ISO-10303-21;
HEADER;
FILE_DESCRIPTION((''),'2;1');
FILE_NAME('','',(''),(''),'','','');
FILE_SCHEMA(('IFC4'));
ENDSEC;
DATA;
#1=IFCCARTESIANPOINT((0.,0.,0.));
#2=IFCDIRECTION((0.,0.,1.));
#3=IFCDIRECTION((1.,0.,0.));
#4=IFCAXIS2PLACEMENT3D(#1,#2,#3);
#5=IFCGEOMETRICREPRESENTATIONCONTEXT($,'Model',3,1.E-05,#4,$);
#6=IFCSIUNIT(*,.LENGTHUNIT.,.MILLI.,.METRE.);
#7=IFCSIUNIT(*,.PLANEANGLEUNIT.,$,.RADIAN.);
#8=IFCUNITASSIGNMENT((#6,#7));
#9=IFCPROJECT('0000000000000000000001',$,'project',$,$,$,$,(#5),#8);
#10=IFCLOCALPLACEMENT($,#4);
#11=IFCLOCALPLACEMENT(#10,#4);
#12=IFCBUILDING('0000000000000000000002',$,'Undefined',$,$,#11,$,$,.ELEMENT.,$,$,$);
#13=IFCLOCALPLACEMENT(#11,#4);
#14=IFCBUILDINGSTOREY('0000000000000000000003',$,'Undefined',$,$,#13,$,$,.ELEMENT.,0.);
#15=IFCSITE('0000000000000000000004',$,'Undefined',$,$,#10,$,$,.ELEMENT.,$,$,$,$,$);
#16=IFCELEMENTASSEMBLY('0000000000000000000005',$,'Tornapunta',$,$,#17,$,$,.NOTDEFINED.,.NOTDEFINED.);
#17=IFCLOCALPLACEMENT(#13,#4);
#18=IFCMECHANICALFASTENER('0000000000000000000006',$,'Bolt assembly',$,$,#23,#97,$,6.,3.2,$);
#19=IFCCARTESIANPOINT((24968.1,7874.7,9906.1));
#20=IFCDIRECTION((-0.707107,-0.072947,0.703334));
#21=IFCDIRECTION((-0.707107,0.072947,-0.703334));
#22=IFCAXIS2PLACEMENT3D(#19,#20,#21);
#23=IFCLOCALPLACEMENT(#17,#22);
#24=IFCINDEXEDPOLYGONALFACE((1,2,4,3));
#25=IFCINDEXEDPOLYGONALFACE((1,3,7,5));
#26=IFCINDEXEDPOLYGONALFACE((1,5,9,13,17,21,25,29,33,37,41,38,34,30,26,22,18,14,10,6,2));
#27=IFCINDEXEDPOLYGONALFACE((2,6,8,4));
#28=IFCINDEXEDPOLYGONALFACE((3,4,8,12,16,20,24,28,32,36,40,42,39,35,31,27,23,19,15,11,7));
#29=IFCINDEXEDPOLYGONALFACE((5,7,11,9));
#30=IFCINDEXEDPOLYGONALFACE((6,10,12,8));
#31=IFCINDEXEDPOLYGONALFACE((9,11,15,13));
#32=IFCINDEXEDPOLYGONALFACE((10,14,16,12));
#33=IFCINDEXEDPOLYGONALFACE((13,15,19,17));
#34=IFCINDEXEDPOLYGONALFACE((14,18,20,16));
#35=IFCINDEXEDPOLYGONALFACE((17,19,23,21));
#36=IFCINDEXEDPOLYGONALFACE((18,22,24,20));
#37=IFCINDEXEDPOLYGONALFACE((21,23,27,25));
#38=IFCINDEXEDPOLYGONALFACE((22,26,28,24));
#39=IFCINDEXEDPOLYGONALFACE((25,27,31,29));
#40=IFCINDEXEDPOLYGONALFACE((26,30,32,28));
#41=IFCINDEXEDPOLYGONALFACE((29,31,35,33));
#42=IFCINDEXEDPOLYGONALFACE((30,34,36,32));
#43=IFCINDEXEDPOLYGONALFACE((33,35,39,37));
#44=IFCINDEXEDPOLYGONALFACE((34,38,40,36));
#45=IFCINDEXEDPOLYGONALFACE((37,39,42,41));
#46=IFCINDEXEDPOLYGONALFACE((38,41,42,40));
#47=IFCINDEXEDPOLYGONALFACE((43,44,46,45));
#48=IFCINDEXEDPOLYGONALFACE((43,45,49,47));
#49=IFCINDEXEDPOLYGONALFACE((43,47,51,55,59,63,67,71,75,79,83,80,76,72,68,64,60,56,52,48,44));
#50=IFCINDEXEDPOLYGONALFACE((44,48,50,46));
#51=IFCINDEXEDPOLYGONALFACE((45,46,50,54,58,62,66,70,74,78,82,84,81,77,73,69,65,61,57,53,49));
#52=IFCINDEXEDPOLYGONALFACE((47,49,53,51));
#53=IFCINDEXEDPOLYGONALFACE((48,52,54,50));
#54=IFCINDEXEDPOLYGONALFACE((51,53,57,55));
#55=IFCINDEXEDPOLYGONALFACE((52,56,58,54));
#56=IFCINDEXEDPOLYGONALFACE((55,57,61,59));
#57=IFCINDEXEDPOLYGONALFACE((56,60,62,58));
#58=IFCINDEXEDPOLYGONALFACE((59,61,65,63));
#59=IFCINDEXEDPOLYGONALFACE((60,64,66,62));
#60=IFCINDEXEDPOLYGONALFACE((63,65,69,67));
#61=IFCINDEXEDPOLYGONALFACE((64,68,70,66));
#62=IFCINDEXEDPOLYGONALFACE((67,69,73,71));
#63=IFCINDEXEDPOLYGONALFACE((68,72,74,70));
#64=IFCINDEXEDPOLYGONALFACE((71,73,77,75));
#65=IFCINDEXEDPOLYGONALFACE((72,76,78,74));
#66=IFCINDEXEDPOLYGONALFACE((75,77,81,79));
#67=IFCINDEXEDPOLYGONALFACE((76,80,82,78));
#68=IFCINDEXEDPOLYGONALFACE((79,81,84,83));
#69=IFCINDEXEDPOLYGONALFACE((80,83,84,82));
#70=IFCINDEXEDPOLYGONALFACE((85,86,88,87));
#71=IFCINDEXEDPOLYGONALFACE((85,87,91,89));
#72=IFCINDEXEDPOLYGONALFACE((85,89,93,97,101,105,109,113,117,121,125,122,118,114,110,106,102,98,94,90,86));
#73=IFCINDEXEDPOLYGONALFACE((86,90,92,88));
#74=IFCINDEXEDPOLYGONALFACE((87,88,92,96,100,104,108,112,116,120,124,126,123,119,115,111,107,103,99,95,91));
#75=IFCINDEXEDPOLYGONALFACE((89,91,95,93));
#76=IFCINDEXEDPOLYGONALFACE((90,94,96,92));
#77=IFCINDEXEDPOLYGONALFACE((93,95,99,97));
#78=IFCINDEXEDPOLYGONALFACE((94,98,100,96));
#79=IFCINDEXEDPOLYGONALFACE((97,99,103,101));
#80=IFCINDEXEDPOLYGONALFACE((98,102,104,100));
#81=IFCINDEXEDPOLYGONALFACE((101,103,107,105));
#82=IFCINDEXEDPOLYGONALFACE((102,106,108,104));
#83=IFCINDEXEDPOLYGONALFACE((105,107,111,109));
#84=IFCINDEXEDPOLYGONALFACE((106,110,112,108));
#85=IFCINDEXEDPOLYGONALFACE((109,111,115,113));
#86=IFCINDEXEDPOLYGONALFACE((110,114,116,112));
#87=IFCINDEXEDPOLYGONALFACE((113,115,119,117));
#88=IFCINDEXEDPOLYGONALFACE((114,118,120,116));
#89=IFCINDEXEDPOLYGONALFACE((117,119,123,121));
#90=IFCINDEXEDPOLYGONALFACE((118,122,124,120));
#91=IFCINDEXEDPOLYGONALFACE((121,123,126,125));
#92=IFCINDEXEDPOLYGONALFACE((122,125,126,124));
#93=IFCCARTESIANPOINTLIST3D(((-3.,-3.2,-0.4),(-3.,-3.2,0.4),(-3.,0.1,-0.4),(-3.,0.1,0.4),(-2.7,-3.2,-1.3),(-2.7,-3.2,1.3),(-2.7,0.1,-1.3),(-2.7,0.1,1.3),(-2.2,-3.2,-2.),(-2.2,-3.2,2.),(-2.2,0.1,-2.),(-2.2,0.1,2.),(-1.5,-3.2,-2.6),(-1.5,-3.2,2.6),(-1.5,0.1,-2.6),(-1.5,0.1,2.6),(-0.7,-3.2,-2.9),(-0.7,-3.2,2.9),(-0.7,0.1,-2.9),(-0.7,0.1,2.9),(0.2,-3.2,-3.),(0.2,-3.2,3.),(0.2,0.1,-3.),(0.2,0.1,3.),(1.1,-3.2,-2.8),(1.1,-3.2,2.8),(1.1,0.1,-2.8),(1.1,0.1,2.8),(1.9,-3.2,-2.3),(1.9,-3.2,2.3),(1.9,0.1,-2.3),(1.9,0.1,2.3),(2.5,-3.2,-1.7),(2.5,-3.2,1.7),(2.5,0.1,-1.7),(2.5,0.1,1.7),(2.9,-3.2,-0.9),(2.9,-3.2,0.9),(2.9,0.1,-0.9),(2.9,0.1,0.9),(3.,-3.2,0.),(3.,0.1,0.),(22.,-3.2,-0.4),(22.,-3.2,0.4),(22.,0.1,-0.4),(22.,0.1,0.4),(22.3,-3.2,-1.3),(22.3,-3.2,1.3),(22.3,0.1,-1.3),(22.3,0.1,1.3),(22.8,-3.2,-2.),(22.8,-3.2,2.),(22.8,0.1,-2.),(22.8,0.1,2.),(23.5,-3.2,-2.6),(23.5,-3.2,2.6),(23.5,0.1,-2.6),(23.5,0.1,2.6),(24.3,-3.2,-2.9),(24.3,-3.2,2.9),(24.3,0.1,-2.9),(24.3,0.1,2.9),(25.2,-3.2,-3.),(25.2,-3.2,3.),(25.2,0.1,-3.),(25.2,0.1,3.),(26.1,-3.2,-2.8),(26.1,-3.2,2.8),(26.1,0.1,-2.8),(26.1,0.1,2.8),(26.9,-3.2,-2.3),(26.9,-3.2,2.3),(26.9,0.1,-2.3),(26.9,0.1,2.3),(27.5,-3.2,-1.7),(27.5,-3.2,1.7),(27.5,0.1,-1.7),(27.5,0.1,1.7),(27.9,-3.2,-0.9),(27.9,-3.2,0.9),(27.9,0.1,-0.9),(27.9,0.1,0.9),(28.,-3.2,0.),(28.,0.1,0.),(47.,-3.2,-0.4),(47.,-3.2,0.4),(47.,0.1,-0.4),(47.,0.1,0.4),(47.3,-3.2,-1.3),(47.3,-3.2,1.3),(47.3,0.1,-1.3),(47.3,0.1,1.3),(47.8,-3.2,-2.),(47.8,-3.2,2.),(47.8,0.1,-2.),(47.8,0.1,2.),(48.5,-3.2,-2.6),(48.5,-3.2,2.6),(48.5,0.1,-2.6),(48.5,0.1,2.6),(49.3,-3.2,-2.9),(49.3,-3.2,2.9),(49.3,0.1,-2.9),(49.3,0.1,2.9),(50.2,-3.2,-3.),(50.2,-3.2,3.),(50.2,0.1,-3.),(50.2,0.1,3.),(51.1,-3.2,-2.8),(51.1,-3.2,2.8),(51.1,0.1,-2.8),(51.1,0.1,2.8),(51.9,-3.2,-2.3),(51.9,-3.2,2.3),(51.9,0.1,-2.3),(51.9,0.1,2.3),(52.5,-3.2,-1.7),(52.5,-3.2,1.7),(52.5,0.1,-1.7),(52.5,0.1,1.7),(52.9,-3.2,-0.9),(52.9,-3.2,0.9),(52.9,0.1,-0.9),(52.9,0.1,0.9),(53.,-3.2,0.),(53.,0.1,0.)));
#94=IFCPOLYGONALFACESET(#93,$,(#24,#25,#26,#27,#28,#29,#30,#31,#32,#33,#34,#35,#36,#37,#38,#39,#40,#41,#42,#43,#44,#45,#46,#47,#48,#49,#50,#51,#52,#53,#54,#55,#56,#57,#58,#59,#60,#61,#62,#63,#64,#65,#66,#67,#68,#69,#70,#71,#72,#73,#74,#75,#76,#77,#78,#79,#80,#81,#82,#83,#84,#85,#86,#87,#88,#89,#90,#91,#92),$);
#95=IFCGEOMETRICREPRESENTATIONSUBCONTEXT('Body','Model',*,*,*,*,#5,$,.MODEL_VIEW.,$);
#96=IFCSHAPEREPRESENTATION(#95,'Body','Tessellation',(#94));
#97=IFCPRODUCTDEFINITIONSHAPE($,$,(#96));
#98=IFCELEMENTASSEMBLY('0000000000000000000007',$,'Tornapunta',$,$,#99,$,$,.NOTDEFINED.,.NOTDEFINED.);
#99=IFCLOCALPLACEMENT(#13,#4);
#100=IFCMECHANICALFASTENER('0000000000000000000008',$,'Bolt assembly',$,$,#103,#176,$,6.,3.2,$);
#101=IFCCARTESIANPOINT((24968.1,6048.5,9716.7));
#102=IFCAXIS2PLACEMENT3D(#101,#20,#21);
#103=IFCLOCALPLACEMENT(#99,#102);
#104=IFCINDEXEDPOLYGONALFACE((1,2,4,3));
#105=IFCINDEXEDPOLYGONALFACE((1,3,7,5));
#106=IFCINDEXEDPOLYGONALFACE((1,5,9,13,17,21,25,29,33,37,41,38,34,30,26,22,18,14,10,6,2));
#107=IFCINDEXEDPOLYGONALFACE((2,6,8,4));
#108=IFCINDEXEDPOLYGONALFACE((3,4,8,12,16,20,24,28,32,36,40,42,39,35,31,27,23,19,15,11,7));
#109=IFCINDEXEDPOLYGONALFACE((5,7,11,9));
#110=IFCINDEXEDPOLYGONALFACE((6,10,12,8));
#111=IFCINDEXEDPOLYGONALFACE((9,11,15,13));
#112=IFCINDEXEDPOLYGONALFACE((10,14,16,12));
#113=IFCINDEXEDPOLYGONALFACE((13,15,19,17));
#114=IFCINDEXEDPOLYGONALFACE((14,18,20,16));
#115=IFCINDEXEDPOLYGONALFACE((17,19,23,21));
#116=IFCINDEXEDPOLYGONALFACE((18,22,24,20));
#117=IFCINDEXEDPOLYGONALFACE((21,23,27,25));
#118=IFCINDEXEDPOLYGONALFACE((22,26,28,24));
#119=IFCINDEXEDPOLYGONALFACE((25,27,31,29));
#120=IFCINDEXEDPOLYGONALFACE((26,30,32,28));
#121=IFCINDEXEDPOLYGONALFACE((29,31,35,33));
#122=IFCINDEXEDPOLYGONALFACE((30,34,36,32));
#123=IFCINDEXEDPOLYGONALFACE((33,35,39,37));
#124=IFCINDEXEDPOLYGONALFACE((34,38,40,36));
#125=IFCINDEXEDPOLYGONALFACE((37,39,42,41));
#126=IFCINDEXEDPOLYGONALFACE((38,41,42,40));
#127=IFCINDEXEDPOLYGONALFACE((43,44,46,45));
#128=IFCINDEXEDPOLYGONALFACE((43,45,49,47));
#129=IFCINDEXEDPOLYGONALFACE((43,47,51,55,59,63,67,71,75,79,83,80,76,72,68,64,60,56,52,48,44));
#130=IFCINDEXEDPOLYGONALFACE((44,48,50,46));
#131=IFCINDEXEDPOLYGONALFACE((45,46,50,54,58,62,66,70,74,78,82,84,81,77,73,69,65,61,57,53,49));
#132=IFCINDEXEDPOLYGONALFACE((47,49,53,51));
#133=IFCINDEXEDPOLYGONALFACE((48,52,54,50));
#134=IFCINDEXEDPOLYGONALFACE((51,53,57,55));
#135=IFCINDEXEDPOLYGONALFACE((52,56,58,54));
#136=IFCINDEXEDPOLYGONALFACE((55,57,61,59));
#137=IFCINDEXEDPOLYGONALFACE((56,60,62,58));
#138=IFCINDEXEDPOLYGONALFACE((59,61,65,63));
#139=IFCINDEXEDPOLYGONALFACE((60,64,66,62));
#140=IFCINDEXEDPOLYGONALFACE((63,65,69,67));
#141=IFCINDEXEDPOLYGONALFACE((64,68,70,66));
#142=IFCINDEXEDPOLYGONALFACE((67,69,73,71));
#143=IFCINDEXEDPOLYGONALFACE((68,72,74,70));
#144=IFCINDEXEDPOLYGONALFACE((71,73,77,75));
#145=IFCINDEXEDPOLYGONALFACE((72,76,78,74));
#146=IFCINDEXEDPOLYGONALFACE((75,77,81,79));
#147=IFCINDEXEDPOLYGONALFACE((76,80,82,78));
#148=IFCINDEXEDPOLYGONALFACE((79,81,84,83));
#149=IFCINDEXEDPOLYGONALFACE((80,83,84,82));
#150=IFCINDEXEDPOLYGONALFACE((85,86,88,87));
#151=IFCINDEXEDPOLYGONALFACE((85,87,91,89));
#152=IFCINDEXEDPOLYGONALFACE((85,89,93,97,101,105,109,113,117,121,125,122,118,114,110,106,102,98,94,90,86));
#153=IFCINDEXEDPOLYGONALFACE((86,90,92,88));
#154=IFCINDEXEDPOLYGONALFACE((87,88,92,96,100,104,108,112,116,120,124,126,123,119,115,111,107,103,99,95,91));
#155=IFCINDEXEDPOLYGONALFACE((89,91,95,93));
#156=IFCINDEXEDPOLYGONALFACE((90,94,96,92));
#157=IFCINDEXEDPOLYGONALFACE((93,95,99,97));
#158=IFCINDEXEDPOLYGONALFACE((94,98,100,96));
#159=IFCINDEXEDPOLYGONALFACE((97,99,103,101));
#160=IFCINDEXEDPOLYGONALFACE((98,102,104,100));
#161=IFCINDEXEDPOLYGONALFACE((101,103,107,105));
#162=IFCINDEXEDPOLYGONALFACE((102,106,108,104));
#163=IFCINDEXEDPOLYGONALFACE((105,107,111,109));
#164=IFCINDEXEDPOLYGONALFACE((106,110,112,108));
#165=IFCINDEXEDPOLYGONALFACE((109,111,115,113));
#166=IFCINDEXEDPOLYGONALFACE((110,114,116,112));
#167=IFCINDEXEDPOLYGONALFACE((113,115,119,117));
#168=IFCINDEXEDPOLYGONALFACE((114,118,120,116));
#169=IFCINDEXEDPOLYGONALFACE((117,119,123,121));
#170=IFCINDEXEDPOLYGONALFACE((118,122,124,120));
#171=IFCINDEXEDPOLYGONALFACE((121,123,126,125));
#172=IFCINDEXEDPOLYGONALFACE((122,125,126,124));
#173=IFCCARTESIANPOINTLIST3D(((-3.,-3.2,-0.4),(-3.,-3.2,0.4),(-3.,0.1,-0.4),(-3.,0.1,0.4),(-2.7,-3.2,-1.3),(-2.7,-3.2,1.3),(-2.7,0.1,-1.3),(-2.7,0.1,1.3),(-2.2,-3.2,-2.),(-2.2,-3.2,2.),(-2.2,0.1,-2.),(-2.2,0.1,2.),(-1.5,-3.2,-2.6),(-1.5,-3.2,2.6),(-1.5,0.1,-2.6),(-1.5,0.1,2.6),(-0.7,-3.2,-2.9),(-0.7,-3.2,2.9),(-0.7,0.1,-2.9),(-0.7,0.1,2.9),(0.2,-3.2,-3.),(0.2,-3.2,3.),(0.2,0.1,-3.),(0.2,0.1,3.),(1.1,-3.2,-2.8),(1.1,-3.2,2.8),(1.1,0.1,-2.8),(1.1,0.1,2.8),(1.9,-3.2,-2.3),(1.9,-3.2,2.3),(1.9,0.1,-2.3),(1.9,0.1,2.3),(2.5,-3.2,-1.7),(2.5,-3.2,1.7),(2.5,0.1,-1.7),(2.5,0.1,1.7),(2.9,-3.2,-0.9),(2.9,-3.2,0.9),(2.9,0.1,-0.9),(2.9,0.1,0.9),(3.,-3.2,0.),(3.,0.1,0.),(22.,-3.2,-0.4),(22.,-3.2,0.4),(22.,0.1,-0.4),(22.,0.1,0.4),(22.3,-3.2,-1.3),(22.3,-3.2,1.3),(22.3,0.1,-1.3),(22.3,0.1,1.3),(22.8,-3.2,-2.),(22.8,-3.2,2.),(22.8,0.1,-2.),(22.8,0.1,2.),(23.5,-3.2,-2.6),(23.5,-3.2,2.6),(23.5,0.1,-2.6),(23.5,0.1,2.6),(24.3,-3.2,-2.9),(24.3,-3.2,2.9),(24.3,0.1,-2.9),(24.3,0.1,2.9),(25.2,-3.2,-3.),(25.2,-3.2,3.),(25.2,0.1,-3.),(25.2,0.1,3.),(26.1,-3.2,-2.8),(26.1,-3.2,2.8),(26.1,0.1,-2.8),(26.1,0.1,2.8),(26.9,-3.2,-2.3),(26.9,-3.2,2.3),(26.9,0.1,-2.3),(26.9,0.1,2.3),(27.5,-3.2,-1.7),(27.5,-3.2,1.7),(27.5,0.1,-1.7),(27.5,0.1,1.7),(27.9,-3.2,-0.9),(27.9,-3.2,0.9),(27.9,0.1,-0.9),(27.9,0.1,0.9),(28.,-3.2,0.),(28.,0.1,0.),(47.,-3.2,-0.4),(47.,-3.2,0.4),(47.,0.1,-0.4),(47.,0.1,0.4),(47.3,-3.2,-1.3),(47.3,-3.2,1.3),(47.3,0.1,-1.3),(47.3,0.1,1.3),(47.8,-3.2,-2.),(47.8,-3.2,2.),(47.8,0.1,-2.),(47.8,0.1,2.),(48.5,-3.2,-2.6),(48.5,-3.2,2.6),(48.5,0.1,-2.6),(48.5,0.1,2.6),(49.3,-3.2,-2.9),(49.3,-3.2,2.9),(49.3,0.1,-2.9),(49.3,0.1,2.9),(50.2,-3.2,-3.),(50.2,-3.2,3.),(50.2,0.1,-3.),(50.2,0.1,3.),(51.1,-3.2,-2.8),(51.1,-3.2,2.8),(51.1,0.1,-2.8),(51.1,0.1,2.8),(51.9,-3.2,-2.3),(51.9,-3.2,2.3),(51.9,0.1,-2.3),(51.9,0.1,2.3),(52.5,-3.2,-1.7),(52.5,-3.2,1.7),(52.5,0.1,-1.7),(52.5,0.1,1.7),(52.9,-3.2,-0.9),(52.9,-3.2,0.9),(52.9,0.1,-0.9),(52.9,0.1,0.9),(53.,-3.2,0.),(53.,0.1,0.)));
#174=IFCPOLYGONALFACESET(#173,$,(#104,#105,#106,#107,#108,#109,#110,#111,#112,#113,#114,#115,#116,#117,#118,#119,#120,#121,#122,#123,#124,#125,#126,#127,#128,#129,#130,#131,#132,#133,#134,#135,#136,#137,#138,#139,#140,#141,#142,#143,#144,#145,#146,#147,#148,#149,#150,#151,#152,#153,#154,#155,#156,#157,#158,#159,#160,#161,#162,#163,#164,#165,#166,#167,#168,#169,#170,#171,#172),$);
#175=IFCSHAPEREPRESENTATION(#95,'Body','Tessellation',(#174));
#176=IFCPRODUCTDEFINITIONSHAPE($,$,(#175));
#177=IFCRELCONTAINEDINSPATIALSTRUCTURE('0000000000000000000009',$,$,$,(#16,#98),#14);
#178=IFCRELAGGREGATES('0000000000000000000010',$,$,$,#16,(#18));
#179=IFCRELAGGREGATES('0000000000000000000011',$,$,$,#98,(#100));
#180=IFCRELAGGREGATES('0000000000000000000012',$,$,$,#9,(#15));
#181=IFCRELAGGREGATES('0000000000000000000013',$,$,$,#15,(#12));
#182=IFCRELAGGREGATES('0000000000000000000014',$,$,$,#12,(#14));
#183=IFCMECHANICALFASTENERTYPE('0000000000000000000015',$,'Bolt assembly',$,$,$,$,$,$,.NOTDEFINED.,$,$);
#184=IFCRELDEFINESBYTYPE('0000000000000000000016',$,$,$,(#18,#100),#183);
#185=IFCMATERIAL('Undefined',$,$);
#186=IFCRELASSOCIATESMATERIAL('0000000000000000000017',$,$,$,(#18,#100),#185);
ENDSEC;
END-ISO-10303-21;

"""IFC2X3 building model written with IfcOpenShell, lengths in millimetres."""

from ifc_helpers import new_model, si_unit, frame, origin_with_axes, origin_2d_with_axis, place, context, subcontext, project, spatial, circle, extrude, source, transform, mapped, material, type_object, element, aggregate, save


model = new_model("IFC2X3")

# Units and contexts
model_context = context("Model", 3, precision=1e-05, world=origin_with_axes())
body_context = subcontext(model_context, "Body", "Model", "MODEL_VIEW")
ifc_project = project(units=[si_unit("LENGTHUNIT", "METRE", prefix="MILLI"), si_unit("PLANEANGLEUNIT", "RADIAN")], contexts=[model_context])

# Site, building, storey
site_placement = place(None, origin_with_axes())
site = spatial("IfcSite", under=ifc_project, at=site_placement, Name="Undefined", CompositionType="ELEMENT")
building_placement = place(site_placement, origin_with_axes())
building = spatial("IfcBuilding", under=site, at=building_placement, Name="Undefined", CompositionType="ELEMENT")
storey_placement = place(building_placement, origin_with_axes())
storey = spatial("IfcBuildingStorey", under=building, at=storey_placement, Name="Undefined", CompositionType="ELEMENT", Elevation=0.0)

# Shared definitions
ifc_material_1 = material(Name="Undefined")
mechanical_fastener_type = type_object("IfcMechanicalFastenerType", Name="Bolt assembly")
shared_shape_1 = source(origin_with_axes(), body_context, "Body", "SweptSolid", [
    extrude(circle(Radius=3.0, at=origin_2d_with_axis()), frame((0.0, -3.2, 0.0), z_axis=(0.0, 1.0, 0.0), x_axis=(1.0, 0.0, 0.0)), (0.0, 0.0, 1.0), 3.3),
])

# Element assemblies, mechanical fasteners
assembly_1_placement = place(storey_placement, origin_with_axes())
assembly_1 = element("IfcElementAssembly", 1, at=assembly_1_placement, inside=storey, Name="Tornapunta", AssemblyPlace="NOTDEFINED", PredefinedType="NOTDEFINED")
mechanical_fastener_1_placement = place(assembly_1_placement, frame((24968.1, 7874.7, 9906.1), z_axis=(-0.707107, -0.072947, 0.703334), x_axis=(-0.707107, 0.072947, -0.703334)))
mechanical_fastener_1 = element("IfcMechanicalFastener", 2, at=mechanical_fastener_1_placement, type_object=mechanical_fastener_type, material=ifc_material_1, Name="Bolt assembly", NominalDiameter=6.0, NominalLength=3.2, context=body_context, shape_type="MappedRepresentation", body=[
    mapped(shared_shape_1, transform((0.0, 0.0, 0.0))),
    mapped(shared_shape_1, transform((25.0, 0.0, 0.0))),
    mapped(shared_shape_1, transform((50.0, 0.0, 0.0))),
])
assembly_2_placement = place(storey_placement, origin_with_axes())
assembly_2 = element("IfcElementAssembly", 3, at=assembly_2_placement, inside=storey, Name="Tornapunta", AssemblyPlace="NOTDEFINED", PredefinedType="NOTDEFINED")
mechanical_fastener_2_placement = place(assembly_2_placement, frame((24968.1, 6048.5, 9716.7), z_axis=(-0.707107, -0.072947, 0.703334), x_axis=(-0.707107, 0.072947, -0.703334)))
mechanical_fastener_2 = element("IfcMechanicalFastener", 4, at=mechanical_fastener_2_placement, type_object=mechanical_fastener_type, material=ifc_material_1, Name="Bolt assembly", NominalDiameter=6.0, NominalLength=3.2, context=body_context, shape_type="MappedRepresentation", body=[
    mapped(shared_shape_1, transform((0.0, 0.0, 0.0))),
    mapped(shared_shape_1, transform((25.0, 0.0, 0.0))),
    mapped(shared_shape_1, transform((50.0, 0.0, 0.0))),
])

aggregate(assembly_1, [mechanical_fastener_1])
aggregate(assembly_2, [mechanical_fastener_2])

save(model, "model.ifc")
